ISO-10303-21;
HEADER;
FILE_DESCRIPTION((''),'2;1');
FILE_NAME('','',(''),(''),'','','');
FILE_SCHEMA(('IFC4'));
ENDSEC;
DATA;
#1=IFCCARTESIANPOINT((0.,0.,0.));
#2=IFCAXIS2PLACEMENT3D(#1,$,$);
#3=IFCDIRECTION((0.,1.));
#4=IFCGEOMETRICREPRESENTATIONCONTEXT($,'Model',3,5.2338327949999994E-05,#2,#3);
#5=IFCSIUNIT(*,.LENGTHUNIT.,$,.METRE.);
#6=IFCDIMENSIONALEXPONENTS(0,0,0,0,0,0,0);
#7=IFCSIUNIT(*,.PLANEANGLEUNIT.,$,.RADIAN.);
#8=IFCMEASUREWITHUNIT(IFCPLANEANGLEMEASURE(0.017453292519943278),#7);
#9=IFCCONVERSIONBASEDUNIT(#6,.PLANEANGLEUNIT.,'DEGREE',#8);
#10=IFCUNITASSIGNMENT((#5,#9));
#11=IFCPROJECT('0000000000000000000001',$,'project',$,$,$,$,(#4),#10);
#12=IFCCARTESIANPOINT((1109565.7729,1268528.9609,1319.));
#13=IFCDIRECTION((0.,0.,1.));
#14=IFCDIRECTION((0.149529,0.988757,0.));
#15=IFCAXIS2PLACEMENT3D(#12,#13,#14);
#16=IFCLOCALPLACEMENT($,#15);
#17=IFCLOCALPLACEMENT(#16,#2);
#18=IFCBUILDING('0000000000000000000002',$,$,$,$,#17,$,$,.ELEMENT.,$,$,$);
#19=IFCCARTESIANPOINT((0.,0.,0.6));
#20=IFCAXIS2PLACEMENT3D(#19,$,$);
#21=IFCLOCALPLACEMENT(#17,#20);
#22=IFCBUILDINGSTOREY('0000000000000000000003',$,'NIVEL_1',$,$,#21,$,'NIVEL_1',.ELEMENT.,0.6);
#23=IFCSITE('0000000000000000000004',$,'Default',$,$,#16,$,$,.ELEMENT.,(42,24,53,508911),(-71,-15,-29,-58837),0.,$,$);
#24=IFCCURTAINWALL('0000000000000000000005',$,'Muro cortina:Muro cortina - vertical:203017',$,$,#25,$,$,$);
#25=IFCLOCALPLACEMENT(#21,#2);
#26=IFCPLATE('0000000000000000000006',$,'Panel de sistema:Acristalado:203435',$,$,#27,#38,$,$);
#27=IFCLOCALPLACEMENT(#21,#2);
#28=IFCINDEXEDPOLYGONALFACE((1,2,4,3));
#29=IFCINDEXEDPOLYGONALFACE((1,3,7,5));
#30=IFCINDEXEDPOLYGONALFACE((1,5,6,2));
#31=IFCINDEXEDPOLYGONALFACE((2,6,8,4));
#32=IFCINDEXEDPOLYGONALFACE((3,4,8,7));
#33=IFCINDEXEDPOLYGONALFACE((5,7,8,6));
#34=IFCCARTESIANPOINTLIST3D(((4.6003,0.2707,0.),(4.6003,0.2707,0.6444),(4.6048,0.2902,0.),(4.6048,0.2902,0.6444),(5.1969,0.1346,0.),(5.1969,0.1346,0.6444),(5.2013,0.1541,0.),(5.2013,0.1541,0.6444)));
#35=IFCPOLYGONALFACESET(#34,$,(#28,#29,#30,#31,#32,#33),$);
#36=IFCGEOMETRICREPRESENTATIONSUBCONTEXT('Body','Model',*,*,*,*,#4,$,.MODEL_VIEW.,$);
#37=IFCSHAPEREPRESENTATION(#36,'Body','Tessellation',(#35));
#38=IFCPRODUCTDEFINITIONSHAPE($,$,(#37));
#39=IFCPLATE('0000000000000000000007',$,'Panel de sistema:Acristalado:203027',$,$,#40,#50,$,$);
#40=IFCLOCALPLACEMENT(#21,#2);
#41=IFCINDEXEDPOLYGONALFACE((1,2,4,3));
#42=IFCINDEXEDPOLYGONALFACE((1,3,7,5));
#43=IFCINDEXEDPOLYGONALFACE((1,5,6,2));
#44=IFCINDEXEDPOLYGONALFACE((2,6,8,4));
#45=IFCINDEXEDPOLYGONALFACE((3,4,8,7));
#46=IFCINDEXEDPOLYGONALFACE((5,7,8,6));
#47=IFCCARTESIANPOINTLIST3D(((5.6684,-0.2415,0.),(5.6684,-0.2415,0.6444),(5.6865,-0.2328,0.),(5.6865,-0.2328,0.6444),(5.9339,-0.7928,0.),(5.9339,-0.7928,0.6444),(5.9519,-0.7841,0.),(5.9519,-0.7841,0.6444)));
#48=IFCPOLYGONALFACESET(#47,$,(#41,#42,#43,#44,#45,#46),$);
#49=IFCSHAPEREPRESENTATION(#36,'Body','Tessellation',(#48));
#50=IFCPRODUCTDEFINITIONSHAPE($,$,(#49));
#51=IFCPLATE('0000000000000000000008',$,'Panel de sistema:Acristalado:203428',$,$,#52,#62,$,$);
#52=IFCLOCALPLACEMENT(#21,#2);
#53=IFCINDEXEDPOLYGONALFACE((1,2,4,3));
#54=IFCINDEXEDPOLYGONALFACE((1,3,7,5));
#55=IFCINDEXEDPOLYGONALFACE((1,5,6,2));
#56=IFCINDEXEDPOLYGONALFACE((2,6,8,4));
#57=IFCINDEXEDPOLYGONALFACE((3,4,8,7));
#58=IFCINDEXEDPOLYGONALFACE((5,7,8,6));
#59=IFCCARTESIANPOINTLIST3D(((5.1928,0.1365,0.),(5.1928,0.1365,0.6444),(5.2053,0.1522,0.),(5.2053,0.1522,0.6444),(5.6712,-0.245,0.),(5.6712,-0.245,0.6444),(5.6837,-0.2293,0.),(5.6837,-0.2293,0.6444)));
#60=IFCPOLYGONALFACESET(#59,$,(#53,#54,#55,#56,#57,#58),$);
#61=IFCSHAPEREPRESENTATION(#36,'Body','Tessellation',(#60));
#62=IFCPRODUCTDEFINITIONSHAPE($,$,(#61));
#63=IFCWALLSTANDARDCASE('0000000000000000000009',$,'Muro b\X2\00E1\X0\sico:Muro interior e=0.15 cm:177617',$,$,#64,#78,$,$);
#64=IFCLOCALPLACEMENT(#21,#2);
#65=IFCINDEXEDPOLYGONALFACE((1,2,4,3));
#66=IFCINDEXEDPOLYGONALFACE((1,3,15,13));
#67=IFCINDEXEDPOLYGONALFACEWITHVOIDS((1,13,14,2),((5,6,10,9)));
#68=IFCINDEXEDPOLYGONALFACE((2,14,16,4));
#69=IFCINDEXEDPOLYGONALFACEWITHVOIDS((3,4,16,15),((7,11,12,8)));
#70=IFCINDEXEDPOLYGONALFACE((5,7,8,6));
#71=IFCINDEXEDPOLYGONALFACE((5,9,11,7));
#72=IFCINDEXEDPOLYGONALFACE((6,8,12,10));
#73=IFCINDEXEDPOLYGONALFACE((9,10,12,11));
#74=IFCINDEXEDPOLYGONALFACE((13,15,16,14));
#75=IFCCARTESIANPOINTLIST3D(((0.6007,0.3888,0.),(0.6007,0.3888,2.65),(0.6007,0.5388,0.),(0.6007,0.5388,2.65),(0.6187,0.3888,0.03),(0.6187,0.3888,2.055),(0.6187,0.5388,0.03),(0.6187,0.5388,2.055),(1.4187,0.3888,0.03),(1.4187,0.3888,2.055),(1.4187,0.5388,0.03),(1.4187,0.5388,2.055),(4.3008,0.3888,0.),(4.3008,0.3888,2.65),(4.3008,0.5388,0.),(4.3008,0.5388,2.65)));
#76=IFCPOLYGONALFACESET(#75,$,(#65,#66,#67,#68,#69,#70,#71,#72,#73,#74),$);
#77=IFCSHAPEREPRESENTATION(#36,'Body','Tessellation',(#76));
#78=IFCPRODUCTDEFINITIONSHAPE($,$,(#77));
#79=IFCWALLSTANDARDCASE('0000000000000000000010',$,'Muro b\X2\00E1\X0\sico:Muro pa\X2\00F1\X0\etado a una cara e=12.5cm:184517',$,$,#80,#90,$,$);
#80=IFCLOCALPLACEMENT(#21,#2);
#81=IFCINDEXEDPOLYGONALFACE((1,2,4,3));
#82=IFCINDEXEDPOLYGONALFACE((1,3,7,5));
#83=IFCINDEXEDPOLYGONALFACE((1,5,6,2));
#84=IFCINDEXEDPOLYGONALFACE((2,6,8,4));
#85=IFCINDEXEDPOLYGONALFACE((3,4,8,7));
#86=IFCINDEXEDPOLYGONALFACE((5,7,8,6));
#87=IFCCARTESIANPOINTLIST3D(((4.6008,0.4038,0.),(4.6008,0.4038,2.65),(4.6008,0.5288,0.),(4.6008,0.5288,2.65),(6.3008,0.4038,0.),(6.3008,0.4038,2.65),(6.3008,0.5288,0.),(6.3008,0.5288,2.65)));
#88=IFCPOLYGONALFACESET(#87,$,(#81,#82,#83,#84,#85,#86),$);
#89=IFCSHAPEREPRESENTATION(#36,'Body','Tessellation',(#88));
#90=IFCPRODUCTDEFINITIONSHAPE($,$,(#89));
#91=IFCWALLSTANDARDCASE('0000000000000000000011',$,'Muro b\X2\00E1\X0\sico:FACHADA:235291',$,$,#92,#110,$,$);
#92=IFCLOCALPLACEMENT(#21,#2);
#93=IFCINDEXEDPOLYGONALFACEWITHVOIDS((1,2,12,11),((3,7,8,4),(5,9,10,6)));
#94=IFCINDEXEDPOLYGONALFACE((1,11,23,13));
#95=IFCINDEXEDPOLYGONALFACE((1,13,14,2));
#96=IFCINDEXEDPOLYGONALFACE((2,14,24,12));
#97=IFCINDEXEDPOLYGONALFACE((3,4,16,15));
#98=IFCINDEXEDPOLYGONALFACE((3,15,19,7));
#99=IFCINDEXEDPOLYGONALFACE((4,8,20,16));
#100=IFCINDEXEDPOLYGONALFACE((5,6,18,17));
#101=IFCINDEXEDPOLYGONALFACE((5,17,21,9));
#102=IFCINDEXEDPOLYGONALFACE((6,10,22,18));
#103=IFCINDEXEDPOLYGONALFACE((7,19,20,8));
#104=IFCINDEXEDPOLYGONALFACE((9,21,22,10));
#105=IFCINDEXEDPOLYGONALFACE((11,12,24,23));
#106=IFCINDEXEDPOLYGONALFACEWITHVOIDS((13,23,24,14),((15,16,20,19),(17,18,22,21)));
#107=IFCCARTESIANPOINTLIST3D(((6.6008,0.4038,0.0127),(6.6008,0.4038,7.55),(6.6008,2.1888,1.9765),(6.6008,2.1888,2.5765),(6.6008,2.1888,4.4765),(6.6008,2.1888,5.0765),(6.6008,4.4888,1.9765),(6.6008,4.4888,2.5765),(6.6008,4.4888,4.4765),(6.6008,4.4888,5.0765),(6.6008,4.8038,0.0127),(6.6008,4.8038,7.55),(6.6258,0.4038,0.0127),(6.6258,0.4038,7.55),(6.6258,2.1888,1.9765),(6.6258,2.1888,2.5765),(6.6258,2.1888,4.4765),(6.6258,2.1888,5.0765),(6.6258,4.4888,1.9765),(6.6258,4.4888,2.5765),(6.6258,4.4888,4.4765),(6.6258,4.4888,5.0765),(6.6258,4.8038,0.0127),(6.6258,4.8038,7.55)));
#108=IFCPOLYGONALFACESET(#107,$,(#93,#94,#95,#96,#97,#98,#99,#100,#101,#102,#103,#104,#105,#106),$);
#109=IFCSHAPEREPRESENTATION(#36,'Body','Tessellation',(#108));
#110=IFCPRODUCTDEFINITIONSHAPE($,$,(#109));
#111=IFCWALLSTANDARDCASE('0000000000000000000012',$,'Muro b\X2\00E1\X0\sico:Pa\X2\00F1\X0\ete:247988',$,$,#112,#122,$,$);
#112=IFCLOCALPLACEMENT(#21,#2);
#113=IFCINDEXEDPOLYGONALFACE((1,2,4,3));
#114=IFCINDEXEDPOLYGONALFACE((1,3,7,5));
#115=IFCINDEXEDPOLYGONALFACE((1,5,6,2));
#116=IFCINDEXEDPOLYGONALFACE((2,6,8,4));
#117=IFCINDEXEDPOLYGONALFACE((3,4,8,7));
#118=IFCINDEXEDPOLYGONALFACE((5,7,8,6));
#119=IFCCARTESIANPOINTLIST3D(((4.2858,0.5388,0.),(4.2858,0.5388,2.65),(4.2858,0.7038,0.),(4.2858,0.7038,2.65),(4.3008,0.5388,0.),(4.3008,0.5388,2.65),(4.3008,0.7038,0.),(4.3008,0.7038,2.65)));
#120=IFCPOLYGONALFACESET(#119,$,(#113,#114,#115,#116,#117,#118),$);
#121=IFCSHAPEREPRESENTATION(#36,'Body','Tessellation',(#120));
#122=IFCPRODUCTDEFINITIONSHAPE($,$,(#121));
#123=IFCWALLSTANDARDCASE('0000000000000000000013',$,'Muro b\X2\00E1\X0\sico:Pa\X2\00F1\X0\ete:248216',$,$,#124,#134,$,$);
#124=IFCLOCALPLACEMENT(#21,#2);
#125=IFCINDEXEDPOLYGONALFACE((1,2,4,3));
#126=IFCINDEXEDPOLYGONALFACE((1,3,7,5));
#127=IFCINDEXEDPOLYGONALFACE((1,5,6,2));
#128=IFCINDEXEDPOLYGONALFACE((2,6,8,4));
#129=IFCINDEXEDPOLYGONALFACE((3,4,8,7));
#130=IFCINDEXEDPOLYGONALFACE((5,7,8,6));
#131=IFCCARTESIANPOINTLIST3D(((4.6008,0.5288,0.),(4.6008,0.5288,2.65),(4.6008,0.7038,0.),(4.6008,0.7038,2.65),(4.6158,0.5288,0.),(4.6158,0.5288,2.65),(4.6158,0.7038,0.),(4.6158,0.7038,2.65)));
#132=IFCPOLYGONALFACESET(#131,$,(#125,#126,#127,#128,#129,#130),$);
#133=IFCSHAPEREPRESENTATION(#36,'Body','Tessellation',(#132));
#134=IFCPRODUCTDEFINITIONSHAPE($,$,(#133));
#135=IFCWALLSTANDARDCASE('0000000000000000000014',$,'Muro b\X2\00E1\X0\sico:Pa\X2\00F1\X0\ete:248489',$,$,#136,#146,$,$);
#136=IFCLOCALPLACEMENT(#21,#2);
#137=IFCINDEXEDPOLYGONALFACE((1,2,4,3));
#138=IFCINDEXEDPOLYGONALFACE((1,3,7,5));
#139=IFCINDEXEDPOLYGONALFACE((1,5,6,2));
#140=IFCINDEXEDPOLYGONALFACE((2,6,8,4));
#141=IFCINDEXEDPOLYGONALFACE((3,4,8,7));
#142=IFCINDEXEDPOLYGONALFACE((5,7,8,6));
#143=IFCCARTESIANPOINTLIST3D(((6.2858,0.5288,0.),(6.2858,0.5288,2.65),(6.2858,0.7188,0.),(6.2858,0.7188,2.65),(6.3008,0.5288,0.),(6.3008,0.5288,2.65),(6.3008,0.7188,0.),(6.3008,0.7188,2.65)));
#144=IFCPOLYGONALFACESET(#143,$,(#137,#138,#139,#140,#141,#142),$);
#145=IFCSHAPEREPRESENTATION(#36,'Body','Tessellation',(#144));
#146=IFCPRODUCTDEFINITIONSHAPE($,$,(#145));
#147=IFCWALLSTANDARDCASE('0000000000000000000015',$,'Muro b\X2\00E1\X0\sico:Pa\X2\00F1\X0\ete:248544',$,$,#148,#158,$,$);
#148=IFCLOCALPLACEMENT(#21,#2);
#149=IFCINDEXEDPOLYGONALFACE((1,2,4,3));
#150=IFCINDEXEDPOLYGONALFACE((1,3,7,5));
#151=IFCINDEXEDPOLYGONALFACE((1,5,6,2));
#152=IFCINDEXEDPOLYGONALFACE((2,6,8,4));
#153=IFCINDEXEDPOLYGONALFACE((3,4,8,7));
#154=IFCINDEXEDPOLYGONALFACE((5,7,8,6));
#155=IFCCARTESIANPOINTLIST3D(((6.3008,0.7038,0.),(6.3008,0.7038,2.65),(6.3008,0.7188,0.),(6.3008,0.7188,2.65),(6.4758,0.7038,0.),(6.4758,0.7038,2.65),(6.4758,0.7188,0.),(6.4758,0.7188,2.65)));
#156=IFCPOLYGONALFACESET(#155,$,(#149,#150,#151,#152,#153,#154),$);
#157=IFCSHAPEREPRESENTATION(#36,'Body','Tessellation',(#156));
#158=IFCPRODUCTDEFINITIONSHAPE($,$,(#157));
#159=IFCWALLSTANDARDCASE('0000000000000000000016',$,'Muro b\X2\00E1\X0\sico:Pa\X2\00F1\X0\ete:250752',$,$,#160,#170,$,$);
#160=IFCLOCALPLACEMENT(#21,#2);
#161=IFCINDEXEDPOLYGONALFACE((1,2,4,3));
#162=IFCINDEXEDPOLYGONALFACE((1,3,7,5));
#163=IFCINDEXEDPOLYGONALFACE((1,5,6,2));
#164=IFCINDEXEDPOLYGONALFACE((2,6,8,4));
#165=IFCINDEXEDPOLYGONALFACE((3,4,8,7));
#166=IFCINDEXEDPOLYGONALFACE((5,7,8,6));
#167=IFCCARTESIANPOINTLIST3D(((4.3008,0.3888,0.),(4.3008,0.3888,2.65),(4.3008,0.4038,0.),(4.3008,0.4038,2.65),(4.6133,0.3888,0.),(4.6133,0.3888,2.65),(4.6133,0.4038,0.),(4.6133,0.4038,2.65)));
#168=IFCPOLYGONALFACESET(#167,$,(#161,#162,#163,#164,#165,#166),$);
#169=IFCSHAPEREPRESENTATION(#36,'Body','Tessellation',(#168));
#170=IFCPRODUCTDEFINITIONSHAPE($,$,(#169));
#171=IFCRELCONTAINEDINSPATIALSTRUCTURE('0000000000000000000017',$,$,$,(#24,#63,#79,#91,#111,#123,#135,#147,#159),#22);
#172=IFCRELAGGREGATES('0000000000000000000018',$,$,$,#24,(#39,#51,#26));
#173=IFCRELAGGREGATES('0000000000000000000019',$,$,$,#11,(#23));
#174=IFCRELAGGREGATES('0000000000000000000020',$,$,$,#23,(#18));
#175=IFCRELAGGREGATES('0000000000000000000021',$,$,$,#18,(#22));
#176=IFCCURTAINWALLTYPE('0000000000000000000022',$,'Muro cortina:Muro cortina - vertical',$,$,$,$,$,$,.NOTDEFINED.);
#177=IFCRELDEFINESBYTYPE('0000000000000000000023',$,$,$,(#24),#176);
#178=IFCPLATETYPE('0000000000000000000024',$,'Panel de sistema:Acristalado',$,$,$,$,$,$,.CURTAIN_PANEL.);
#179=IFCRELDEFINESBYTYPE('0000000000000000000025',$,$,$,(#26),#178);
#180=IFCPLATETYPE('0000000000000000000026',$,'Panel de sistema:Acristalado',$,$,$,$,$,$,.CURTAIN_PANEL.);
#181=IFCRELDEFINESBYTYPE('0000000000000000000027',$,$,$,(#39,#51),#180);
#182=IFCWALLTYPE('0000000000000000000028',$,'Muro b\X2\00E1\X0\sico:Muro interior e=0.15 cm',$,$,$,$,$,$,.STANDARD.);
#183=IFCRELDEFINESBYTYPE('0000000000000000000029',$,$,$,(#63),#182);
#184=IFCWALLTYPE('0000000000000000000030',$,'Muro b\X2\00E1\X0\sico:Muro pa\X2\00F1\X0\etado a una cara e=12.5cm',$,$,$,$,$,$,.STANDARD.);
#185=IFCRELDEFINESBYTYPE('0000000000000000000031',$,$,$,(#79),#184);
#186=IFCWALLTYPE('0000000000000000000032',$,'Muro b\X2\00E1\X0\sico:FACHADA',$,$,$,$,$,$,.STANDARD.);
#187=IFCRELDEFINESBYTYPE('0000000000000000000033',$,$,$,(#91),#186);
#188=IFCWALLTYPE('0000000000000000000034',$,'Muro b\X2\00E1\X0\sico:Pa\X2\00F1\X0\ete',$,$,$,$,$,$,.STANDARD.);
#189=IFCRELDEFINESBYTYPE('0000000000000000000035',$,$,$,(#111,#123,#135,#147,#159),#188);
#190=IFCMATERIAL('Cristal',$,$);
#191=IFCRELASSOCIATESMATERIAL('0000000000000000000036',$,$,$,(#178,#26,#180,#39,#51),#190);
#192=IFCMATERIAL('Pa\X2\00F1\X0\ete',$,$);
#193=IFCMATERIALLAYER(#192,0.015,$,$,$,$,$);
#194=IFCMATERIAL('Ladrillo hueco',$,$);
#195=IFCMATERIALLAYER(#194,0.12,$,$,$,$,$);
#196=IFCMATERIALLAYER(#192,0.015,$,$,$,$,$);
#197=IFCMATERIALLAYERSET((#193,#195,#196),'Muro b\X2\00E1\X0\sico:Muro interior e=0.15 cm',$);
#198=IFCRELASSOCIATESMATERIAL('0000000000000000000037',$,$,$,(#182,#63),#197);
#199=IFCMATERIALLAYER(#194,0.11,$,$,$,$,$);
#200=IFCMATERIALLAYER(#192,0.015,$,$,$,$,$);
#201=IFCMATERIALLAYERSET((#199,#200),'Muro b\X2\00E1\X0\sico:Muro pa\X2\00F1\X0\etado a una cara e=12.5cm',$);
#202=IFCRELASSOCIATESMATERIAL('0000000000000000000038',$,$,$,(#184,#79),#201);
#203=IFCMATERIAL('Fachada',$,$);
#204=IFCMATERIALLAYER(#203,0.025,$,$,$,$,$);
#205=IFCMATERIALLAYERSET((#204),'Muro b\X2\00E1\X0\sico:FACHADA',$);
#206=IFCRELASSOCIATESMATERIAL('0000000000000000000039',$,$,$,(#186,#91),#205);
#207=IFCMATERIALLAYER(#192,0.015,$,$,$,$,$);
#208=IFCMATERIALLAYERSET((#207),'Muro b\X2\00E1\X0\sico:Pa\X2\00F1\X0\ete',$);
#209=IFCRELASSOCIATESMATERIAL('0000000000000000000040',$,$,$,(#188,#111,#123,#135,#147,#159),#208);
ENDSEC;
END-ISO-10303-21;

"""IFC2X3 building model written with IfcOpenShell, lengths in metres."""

from ifc_helpers import new_model, entity, si_unit, converted_unit, direction, frame, frame_2d, origin, place, context, subcontext, project, spatial, rectangle, extrude, source, transform, mapped, material, layer, layer_set, layer_usage, type_object, type_shapes, element, aggregate, save


model = new_model("IFC2X3")

# Units and contexts
model_context = context("Model", 3, precision=5.2338327949999994e-05, world=origin(), true_north=direction((0.0, 1.0)))
body_context = subcontext(model_context, "Body", "Model", "MODEL_VIEW")
ifc_project = project(units=[si_unit("LENGTHUNIT", "METRE"), converted_unit("PLANEANGLEUNIT", "DEGREE", entity("IfcPlaneAngleMeasure", 0.017453292519943278), si_unit("PLANEANGLEUNIT", "RADIAN"), dimensions=[0, 0, 0, 0, 0, 0, 0])], contexts=[model_context])

# Site, building, storey
site_placement = place(None, frame((1109565.7729, 1268528.9609, 1319.0), z_axis=(0.0, 0.0, 1.0), x_axis=(0.149529, 0.988757, 0.0)))
site = spatial("IfcSite", under=ifc_project, at=site_placement, Name="Default", CompositionType="ELEMENT", RefLatitude=(42, 24, 53, 508911), RefLongitude=(-71, -15, -29, -58837), RefElevation=0.0)
building_placement = place(site_placement, origin())
building = spatial("IfcBuilding", under=site, at=building_placement, CompositionType="ELEMENT")
storey_placement = place(building_placement, frame((0.0, 0.0, 0.6)))
storey = spatial("IfcBuildingStorey", under=building, at=storey_placement, Name="NIVEL_1", LongName="NIVEL_1", CompositionType="ELEMENT", Elevation=0.6)

# Curtain wall, plates
curtain_wall_type = type_object("IfcCurtainWallType", Name="Muro cortina:Muro cortina - vertical", PredefinedType="NOTDEFINED")
curtain_wall_1_placement = place(storey_placement, frame((0.0, 0.0, -0.6)))
curtain_wall_1 = element("IfcCurtainWall", 1, at=curtain_wall_1_placement, inside=storey, type_object=curtain_wall_type, Name="Muro cortina:Muro cortina - vertical:203017")
ifc_material_1 = material(Name="Cristal")
plate_type_1 = type_object("IfcPlateType", Name="Panel de sistema:Acristalado", PredefinedType="CURTAIN_PANEL", material=ifc_material_1)
shared_shape_1 = source(origin(), body_context, "Body", "SweptSolid", [
    extrude(rectangle(XDim=0.02, YDim=0.6119, at=frame_2d((0.0, 0.0), x_axis=(1.0, 0.0))), frame((0.0, 0.0, 0.0), z_axis=(0.0, 0.0, 1.0), x_axis=(0.0, 1.0, 0.0)), (0.0, 0.0, 1.0), 0.6444),
])
type_shapes(plate_type_1, [shared_shape_1])
plate_1_placement = place(curtain_wall_1_placement, frame((4.9008, 0.2124, 0.6), z_axis=(0.0, 0.0, 1.0), x_axis=(-0.974928, 0.222521, 0.0)))
plate_1 = element("IfcPlate", 2, at=plate_1_placement, type_object=plate_type_1, material=ifc_material_1, Name="Panel de sistema:Acristalado:203435", context=body_context, shape_type="MappedRepresentation", body=[
    mapped(shared_shape_1, transform((0.0, 0.0, 0.0), scale=1.0)),
])
plate_type_2 = type_object("IfcPlateType", Name="Panel de sistema:Acristalado", PredefinedType="CURTAIN_PANEL", material=ifc_material_1)
shared_shape_2 = source(origin(), body_context, "Body", "SweptSolid", [
    extrude(rectangle(XDim=0.02, YDim=0.6119, at=frame_2d((0.0, 0.0), x_axis=(1.0, 0.0))), frame((0.0, 0.0, 0.0), z_axis=(0.0, 0.0, 1.0), x_axis=(0.0, 1.0, 0.0)), (0.0, 0.0, 1.0), 0.6444),
])
type_shapes(plate_type_2, [shared_shape_2])
plate_2_placement = place(curtain_wall_1_placement, frame((5.8102, -0.5128, 0.6), z_axis=(0.0, 0.0, 1.0), x_axis=(-0.433884, 0.900969, 0.0)))
plate_2 = element("IfcPlate", 3, at=plate_2_placement, type_object=plate_type_2, material=ifc_material_1, Name="Panel de sistema:Acristalado:203027", context=body_context, shape_type="MappedRepresentation", body=[
    mapped(shared_shape_2, transform((0.0, 0.0, 0.0), scale=1.0)),
])
plate_3_placement = place(curtain_wall_1_placement, frame((5.4383, -0.0464, 0.6), z_axis=(0.0, 0.0, 1.0), x_axis=(-0.781832, 0.62349, 0.0)))
plate_3 = element("IfcPlate", 4, at=plate_3_placement, type_object=plate_type_2, material=ifc_material_1, Name="Panel de sistema:Acristalado:203428", context=body_context, shape_type="MappedRepresentation", body=[
    mapped(shared_shape_2, transform((0.0, 0.0, 0.0), scale=1.0)),
])
aggregate(curtain_wall_1, [plate_2, plate_3, plate_1])

# Wall, opening
ifc_material_2 = material(Name="Pañete")
ifc_layer_1 = layer(ifc_material_2, 0.015)
ifc_material_3 = material(Name="Ladrillo hueco")
ifc_layer_2 = layer(ifc_material_3, 0.12)
ifc_layer_3 = layer(ifc_material_2, 0.015)
ifc_layer_set_1 = layer_set([ifc_layer_1, ifc_layer_2, ifc_layer_3], Name="Muro básico:Muro interior e=0.15 cm")
ifc_layer_usage_1 = layer_usage(ifc_layer_set_1, "AXIS2", "NEGATIVE", 0.075)
wall_type_1 = type_object("IfcWallType", Name="Muro básico:Muro interior e=0.15 cm", PredefinedType="STANDARD", material=ifc_layer_set_1)
wall_1_placement = place(storey_placement, frame((4.3008, 0.4638, 0.0), z_axis=(0.0, 0.0, 1.0), x_axis=(-1.0, 0.0, 0.0)))
wall_1 = element("IfcWallStandardCase", 5, at=wall_1_placement, inside=storey, type_object=wall_type_1, material=ifc_layer_usage_1, Name="Muro básico:Muro interior e=0.15 cm:177617", context=body_context, shape_type="SweptSolid", body=[
    extrude(rectangle(XDim=3.7, YDim=0.15, at=frame_2d((1.85, 0.0), x_axis=(-1.0, 0.0))), origin(), (0.0, 0.0, 1.0), 2.65),
])
opening_1_placement = place(wall_1_placement, frame((3.682, 0.075, 0.03)))
element("IfcOpeningElement", 6, at=opening_1_placement, cuts=wall_1, ObjectType="Opening", context=body_context, shape_type="SweptSolid", body=[
    extrude(rectangle(XDim=2.025, YDim=0.8, at=frame_2d((1.0125, 0.4), x_axis=(1.0, 0.0))), frame((0.0, 0.0, 0.0), z_axis=(0.0, -1.0, 0.0), x_axis=(0.0, 0.0, 1.0)), (0.0, 0.0, 1.0), 0.15),
])

# Wall
ifc_layer_4 = layer(ifc_material_3, 0.11)
ifc_layer_5 = layer(ifc_material_2, 0.015)
ifc_layer_set_2 = layer_set([ifc_layer_4, ifc_layer_5], Name="Muro básico:Muro pañetado a una cara e=12.5cm")
ifc_layer_usage_2 = layer_usage(ifc_layer_set_2, "AXIS2", "NEGATIVE", 0.0625)
wall_type_2 = type_object("IfcWallType", Name="Muro básico:Muro pañetado a una cara e=12.5cm", PredefinedType="STANDARD", material=ifc_layer_set_2)
wall_2_placement = place(storey_placement, frame((6.3008, 0.4663, 0.0), z_axis=(0.0, 0.0, 1.0), x_axis=(-1.0, 0.0, 0.0)))
element("IfcWallStandardCase", 7, at=wall_2_placement, inside=storey, type_object=wall_type_2, material=ifc_layer_usage_2, Name="Muro básico:Muro pañetado a una cara e=12.5cm:184517", context=body_context, shape_type="SweptSolid", body=[
    extrude(rectangle(XDim=1.7, YDim=0.125, at=frame_2d((0.85, 0.0), x_axis=(-1.0, 0.0))), origin(), (0.0, 0.0, 1.0), 2.65),
])

# Wall, openings
ifc_material_4 = material(Name="Fachada")
ifc_layer_6 = layer(ifc_material_4, 0.025)
ifc_layer_set_3 = layer_set([ifc_layer_6], Name="Muro básico:FACHADA")
ifc_layer_usage_3 = layer_usage(ifc_layer_set_3, "AXIS2", "POSITIVE", -0.0125)
wall_type_3 = type_object("IfcWallType", Name="Muro básico:FACHADA", PredefinedType="STANDARD", material=ifc_layer_set_3)
wall_3_placement = place(storey_placement, frame((6.6133, 0.4038, 0.0127), z_axis=(0.0, 0.0, 1.0), x_axis=(0.0, 1.0, 0.0)))
wall_3 = element("IfcWallStandardCase", 8, at=wall_3_placement, inside=storey, type_object=wall_type_3, material=ifc_layer_usage_3, Name="Muro básico:FACHADA:235291", context=body_context, shape_type="SweptSolid", body=[
    extrude(rectangle(XDim=4.4, YDim=0.025, at=frame_2d((2.2, 0.0), x_axis=(-1.0, 0.0))), origin(), (0.0, 0.0, 1.0), 7.5373),
])
opening_2_placement = place(wall_3_placement, origin())
element("IfcOpeningElement", 9, at=opening_2_placement, cuts=wall_3, ObjectType="Opening", context=body_context, shape_type="SweptSolid", body=[
    extrude(rectangle(XDim=0.6, YDim=2.3, at=frame_2d((0.0, 0.0), x_axis=(0.0, 1.0))), frame((2.935, 0.0125, 2.2638), z_axis=(0.0, -1.0, 0.0), x_axis=(-1.0, 0.0, 0.0)), (0.0, 0.0, 1.0), 0.025),
])
opening_3_placement = place(wall_3_placement, origin())
element("IfcOpeningElement", 10, at=opening_3_placement, cuts=wall_3, ObjectType="Opening", context=body_context, shape_type="SweptSolid", body=[
    extrude(rectangle(XDim=0.6, YDim=2.3, at=frame_2d((0.0, 0.0), x_axis=(0.0, 1.0))), frame((2.935, 0.0125, 4.7638), z_axis=(0.0, -1.0, 0.0), x_axis=(-1.0, 0.0, 0.0)), (0.0, 0.0, 1.0), 0.025),
])

# Walls
ifc_layer_7 = layer(ifc_material_2, 0.015)
ifc_layer_set_4 = layer_set([ifc_layer_7], Name="Muro básico:Pañete")
ifc_layer_usage_4 = layer_usage(ifc_layer_set_4, "AXIS2", "POSITIVE", -0.0075)
wall_type_4 = type_object("IfcWallType", Name="Muro básico:Pañete", PredefinedType="STANDARD", material=ifc_layer_set_4)
wall_4_placement = place(storey_placement, frame((4.2933, 0.7038, 0.0), z_axis=(0.0, 0.0, 1.0), x_axis=(0.0, -1.0, 0.0)))
element("IfcWallStandardCase", 11, at=wall_4_placement, inside=storey, type_object=wall_type_4, material=ifc_layer_usage_4, Name="Muro básico:Pañete:247988", context=body_context, shape_type="SweptSolid", body=[
    extrude(rectangle(XDim=0.165, YDim=0.015, at=frame_2d((0.0825, 0.0), x_axis=(-1.0, 0.0))), origin(), (0.0, 0.0, 1.0), 2.65),
])
ifc_layer_usage_5 = layer_usage(ifc_layer_set_4, "AXIS2", "NEGATIVE", 0.0075)
wall_5_placement = place(storey_placement, frame((4.6083, 0.7038, 0.0), z_axis=(0.0, 0.0, 1.0), x_axis=(0.0, -1.0, 0.0)))
element("IfcWallStandardCase", 12, at=wall_5_placement, inside=storey, type_object=wall_type_4, material=ifc_layer_usage_5, Name="Muro básico:Pañete:248216", context=body_context, shape_type="SweptSolid", body=[
    extrude(rectangle(XDim=0.175, YDim=0.015, at=frame_2d((0.0875, 0.0), x_axis=(-1.0, 0.0))), origin(), (0.0, 0.0, 1.0), 2.65),
])
ifc_layer_usage_6 = layer_usage(ifc_layer_set_4, "AXIS2", "NEGATIVE", 0.0075)
wall_6_placement = place(storey_placement, frame((6.2933, 0.5288, 0.0), z_axis=(0.0, 0.0, 1.0), x_axis=(0.0, 1.0, 0.0)))
element("IfcWallStandardCase", 13, at=wall_6_placement, inside=storey, type_object=wall_type_4, material=ifc_layer_usage_6, Name="Muro básico:Pañete:248489", context=body_context, shape_type="SweptSolid", body=[
    extrude(rectangle(XDim=0.19, YDim=0.015, at=frame_2d((0.095, 0.0), x_axis=(-1.0, 0.0))), origin(), (0.0, 0.0, 1.0), 2.65),
])
ifc_layer_usage_7 = layer_usage(ifc_layer_set_4, "AXIS2", "POSITIVE", -0.0075)
wall_7_placement = place(storey_placement, frame((6.4758, 0.7113, 0.0), z_axis=(0.0, 0.0, 1.0), x_axis=(-1.0, 0.0, 0.0)))
element("IfcWallStandardCase", 14, at=wall_7_placement, inside=storey, type_object=wall_type_4, material=ifc_layer_usage_7, Name="Muro básico:Pañete:248544", context=body_context, shape_type="SweptSolid", body=[
    extrude(rectangle(XDim=0.175, YDim=0.015, at=frame_2d((0.0875, 0.0), x_axis=(-1.0, 0.0))), origin(), (0.0, 0.0, 1.0), 2.65),
])
ifc_layer_usage_8 = layer_usage(ifc_layer_set_4, "AXIS2", "POSITIVE", -0.0075)
wall_8_placement = place(storey_placement, frame((4.3008, 0.3963, 0.0)))
element("IfcWallStandardCase", 15, at=wall_8_placement, inside=storey, type_object=wall_type_4, material=ifc_layer_usage_8, Name="Muro básico:Pañete:250752", context=body_context, shape_type="SweptSolid", body=[
    extrude(rectangle(XDim=0.3125, YDim=0.015, at=frame_2d((0.1563, 0.0), x_axis=(-1.0, 0.0))), origin(), (0.0, 0.0, 1.0), 2.65),
])

save(model, "model.ifc")
